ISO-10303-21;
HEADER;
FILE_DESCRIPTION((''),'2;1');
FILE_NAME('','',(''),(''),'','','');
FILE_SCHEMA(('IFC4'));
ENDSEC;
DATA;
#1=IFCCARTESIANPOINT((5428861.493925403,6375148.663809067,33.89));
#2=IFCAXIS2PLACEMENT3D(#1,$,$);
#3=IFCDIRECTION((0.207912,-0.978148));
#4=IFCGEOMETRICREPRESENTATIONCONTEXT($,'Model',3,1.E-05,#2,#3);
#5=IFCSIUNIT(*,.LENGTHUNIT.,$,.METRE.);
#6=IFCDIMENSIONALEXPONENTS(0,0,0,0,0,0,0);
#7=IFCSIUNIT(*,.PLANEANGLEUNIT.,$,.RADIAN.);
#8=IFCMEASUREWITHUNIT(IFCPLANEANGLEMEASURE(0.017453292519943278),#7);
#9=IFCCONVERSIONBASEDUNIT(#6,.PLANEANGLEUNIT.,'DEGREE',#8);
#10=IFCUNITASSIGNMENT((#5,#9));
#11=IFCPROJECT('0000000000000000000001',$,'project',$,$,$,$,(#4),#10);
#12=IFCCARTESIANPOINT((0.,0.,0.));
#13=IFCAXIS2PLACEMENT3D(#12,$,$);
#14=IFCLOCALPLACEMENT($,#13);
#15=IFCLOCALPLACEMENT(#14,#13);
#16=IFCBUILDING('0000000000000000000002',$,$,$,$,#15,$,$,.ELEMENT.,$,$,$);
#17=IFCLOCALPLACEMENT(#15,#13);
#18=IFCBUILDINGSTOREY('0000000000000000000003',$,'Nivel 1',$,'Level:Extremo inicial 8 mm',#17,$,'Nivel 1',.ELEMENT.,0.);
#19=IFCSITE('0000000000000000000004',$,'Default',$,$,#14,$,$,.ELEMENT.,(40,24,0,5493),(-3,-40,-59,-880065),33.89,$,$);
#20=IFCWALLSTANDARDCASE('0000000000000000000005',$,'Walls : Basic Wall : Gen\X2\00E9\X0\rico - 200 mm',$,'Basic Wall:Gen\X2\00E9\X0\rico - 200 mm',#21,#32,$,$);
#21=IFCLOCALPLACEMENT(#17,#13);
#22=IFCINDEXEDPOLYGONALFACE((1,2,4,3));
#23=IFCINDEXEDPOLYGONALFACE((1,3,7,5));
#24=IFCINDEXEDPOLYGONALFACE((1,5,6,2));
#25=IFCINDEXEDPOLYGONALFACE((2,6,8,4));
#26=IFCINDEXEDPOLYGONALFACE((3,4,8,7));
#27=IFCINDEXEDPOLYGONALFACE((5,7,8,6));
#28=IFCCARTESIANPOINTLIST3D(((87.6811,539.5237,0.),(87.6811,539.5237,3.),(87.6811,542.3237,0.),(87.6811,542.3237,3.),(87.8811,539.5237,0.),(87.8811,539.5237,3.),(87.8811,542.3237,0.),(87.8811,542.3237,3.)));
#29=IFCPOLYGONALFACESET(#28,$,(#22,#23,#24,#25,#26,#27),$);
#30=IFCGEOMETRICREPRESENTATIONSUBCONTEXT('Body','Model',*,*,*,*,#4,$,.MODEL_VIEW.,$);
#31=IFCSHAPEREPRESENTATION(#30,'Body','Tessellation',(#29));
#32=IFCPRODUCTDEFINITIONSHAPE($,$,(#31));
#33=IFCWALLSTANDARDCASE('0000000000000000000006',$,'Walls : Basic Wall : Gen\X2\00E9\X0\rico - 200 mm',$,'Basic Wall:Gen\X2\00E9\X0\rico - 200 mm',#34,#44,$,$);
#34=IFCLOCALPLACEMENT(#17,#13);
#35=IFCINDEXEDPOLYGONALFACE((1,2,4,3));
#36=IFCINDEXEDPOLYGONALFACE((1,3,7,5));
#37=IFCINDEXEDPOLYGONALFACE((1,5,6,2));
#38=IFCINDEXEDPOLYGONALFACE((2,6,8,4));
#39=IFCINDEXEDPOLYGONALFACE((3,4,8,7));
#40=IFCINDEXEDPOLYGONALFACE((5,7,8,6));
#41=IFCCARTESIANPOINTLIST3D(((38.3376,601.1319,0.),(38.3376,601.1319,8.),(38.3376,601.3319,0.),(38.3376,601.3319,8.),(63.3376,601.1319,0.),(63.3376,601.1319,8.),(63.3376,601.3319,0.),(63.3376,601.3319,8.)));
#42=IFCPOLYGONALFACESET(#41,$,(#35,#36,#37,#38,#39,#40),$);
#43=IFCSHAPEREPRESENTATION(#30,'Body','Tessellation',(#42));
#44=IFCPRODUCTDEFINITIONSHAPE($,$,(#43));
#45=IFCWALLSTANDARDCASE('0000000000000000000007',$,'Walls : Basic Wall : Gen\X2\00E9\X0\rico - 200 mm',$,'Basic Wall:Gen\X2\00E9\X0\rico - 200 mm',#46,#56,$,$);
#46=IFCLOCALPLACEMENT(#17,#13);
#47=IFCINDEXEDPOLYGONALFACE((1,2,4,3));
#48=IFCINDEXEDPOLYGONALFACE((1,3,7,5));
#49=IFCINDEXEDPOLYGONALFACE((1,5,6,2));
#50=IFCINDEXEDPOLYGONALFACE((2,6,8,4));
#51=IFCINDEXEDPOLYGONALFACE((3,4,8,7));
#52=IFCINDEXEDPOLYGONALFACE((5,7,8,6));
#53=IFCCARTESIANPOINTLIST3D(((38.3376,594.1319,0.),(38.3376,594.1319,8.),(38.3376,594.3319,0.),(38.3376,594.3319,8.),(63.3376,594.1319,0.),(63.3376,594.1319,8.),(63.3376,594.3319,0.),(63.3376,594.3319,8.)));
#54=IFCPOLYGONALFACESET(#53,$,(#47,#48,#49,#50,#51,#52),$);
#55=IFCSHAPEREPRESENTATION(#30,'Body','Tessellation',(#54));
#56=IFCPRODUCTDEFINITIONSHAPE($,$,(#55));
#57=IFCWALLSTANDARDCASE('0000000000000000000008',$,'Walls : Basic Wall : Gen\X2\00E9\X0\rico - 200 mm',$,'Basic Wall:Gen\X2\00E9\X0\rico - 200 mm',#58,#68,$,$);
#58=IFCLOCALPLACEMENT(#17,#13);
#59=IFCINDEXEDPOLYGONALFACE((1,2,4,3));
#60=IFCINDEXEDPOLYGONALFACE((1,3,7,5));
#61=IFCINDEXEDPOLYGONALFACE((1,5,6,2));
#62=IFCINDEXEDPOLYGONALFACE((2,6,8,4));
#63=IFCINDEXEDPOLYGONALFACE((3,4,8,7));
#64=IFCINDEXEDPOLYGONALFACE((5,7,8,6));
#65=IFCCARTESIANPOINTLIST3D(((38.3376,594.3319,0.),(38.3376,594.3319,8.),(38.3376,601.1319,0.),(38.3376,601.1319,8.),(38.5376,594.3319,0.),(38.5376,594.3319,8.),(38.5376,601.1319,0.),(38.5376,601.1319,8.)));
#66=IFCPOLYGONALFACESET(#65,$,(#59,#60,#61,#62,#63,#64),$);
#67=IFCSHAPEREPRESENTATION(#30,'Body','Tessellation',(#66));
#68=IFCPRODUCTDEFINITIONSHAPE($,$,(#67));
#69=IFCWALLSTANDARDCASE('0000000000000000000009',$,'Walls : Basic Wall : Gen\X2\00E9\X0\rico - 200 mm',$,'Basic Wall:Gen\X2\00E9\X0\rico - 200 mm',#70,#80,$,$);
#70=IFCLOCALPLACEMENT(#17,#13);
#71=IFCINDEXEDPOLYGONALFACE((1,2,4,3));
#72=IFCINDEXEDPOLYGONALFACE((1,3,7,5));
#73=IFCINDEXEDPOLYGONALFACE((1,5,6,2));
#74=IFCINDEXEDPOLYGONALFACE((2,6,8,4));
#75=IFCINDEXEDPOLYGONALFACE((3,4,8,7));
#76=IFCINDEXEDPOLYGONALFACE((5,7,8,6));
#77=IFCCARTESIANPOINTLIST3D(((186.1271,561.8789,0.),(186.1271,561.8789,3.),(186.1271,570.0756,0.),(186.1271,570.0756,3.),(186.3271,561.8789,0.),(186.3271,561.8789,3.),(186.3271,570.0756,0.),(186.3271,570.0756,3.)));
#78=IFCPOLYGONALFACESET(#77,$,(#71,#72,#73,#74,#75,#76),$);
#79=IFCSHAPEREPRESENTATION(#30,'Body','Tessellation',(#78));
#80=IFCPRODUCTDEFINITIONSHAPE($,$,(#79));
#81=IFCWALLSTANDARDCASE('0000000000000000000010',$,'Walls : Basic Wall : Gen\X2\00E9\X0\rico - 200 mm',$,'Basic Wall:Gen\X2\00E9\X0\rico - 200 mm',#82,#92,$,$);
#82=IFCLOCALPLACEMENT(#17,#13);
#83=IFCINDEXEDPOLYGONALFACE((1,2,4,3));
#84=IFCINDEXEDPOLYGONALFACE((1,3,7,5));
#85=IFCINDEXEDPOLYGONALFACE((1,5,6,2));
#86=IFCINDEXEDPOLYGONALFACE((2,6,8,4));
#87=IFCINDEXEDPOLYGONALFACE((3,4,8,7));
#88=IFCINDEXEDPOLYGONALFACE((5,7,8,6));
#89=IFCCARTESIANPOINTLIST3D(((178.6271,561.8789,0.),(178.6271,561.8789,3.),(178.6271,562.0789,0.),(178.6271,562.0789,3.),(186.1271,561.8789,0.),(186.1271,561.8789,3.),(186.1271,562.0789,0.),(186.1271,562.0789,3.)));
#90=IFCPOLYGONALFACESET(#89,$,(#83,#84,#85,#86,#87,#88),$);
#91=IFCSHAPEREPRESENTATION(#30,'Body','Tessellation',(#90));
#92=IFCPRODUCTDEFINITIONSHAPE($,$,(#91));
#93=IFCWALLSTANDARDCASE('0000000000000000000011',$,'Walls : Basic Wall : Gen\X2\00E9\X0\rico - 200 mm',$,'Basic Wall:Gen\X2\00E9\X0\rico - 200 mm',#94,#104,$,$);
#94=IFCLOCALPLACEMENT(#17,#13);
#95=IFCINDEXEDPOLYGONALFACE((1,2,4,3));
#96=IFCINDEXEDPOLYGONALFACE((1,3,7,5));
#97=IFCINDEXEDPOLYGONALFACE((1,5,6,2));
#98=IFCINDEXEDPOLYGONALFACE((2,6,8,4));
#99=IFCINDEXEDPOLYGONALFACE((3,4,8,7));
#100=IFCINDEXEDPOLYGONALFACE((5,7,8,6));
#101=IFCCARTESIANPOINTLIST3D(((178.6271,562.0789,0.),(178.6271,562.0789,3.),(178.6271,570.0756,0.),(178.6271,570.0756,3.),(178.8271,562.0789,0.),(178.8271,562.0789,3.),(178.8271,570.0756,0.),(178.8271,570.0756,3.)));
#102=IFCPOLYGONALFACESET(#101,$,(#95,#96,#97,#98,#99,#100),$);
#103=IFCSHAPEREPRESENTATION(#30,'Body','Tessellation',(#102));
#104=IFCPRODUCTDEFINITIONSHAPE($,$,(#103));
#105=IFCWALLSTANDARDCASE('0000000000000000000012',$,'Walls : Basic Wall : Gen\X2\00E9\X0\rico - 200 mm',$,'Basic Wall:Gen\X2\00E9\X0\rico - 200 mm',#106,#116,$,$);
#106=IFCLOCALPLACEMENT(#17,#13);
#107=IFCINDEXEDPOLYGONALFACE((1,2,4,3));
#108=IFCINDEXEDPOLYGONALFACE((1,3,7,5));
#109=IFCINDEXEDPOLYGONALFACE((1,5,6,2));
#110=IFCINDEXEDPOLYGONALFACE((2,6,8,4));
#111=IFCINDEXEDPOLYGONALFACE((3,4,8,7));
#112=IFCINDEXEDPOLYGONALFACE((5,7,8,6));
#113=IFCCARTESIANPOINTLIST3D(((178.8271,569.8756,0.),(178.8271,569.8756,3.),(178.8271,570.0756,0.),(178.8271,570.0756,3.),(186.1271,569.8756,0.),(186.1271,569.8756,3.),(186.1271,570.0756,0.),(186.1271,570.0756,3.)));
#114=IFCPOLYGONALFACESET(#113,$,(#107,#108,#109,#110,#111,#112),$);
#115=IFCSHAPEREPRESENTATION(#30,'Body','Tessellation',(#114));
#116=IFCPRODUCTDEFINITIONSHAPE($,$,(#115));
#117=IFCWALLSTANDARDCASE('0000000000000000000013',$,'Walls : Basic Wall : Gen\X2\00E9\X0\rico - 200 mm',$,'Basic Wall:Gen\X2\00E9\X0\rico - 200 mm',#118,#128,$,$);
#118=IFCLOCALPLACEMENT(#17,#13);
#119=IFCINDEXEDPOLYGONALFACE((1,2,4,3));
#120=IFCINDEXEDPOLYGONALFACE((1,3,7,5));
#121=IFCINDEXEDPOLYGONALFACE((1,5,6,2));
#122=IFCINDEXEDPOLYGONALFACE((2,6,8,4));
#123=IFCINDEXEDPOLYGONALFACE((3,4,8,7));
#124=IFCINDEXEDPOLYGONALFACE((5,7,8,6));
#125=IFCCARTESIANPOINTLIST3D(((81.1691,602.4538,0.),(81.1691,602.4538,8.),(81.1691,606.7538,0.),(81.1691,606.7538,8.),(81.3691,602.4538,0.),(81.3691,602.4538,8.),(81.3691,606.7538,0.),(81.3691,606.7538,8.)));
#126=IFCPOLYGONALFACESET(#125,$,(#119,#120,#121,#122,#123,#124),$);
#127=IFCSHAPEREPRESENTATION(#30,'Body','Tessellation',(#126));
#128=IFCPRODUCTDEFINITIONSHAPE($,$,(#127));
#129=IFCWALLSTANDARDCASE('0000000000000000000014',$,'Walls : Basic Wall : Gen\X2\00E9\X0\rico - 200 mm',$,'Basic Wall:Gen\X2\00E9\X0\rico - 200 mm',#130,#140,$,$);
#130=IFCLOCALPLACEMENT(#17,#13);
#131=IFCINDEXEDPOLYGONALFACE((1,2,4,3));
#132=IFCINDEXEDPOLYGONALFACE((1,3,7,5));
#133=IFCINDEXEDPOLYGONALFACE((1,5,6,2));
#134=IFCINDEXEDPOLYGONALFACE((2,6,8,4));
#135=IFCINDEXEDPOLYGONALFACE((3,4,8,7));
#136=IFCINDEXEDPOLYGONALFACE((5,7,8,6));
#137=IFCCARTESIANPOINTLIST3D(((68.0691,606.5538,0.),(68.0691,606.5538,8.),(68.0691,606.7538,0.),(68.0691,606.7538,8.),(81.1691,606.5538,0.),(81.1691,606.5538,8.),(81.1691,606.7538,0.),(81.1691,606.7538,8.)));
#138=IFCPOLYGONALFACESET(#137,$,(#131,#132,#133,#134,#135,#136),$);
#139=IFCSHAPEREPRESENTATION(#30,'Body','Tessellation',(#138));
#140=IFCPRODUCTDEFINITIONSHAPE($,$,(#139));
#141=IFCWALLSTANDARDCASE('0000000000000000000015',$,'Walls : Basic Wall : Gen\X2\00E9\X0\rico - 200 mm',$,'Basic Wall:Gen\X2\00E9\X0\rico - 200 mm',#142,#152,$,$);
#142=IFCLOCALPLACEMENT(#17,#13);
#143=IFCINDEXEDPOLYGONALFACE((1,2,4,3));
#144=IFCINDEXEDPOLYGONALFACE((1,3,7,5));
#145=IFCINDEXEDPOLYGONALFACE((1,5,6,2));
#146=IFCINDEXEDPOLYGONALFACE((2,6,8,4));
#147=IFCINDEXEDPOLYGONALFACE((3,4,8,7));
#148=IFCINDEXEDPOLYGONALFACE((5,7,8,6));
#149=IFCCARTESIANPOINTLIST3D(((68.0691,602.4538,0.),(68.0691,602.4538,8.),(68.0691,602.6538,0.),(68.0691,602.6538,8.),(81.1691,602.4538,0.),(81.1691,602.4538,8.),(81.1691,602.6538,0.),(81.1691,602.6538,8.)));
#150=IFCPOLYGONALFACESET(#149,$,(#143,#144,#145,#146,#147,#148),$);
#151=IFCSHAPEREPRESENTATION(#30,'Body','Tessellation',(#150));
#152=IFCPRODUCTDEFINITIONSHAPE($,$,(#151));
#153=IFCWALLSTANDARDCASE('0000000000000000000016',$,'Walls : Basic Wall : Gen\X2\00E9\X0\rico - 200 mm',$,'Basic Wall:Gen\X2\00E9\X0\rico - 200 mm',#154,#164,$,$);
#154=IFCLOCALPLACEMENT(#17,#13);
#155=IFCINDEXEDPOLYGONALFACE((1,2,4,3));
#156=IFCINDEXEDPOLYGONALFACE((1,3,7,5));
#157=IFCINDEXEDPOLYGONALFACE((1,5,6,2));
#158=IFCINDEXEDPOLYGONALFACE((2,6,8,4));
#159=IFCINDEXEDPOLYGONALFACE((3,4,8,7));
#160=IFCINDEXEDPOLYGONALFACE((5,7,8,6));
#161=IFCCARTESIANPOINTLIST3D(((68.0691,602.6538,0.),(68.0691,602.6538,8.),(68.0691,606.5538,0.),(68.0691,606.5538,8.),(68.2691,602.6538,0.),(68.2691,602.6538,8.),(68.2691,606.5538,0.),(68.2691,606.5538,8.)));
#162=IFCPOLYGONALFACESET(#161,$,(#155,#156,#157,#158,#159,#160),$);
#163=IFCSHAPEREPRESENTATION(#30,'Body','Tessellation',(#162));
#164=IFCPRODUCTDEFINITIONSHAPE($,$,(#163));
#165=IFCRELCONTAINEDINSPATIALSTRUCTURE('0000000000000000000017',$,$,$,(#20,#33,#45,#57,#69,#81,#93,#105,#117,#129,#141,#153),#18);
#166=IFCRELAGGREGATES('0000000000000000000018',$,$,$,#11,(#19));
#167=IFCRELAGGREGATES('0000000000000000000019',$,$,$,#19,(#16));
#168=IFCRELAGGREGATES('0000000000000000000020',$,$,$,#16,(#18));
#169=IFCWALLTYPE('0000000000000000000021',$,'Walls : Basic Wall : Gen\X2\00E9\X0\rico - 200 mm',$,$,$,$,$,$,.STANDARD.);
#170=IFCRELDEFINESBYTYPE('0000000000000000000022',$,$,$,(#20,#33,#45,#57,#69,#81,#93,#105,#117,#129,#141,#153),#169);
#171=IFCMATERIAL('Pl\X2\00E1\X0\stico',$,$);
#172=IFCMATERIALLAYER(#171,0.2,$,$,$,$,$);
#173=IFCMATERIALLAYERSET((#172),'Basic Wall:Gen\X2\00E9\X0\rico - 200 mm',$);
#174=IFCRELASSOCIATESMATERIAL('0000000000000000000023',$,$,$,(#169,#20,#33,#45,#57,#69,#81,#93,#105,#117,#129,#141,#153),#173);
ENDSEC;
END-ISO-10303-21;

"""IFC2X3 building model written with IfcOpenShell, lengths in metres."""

from ifc_helpers import new_model, entity, si_unit, converted_unit, direction, frame, frame_2d, origin, place, context, subcontext, project, spatial, rectangle, extrude, material, layer, layer_set, layer_usage, type_object, element, save


model = new_model("IFC2X3")

# Units and contexts
model_context = context("Model", 3, precision=1e-05, world=frame((5428861.493925403, 6375148.663809067, 33.89)), true_north=direction((0.207912, -0.978148)))
body_context = subcontext(model_context, "Body", "Model", "MODEL_VIEW")
ifc_project = project(units=[si_unit("LENGTHUNIT", "METRE"), converted_unit("PLANEANGLEUNIT", "DEGREE", entity("IfcPlaneAngleMeasure", 0.017453292519943278), si_unit("PLANEANGLEUNIT", "RADIAN"), dimensions=[0, 0, 0, 0, 0, 0, 0])], contexts=[model_context])

# Site, building, storey
site_placement = place(None, origin())
site = spatial("IfcSite", under=ifc_project, at=site_placement, Name="Default", CompositionType="ELEMENT", RefLatitude=(40, 24, 0, 5493), RefLongitude=(-3, -40, -59, -880065), RefElevation=33.89)
building_placement = place(site_placement, origin())
building = spatial("IfcBuilding", under=site, at=building_placement, CompositionType="ELEMENT")
storey_placement = place(building_placement, origin())
storey = spatial("IfcBuildingStorey", under=building, at=storey_placement, Name="Nivel 1", ObjectType="Level:Extremo inicial 8 mm", LongName="Nivel 1", CompositionType="ELEMENT", Elevation=0.0)

# Walls
ifc_material_1 = material(Name="Plástico")
ifc_layer_1 = layer(ifc_material_1, 0.2)
ifc_layer_set_1 = layer_set([ifc_layer_1], Name="Basic Wall:Genérico - 200 mm")
wall_type = type_object("IfcWallType", Name="Walls : Basic Wall : Genérico - 200 mm", PredefinedType="STANDARD", material=ifc_layer_set_1)
ifc_layer_usage_1 = layer_usage(ifc_layer_set_1, "AXIS2", "NEGATIVE", 0.1)
wall_1_placement = place(storey_placement, frame((87.7811, 542.3237, 0.0), z_axis=(0.0, 0.0, 1.0), x_axis=(0.0, -1.0, 0.0)))
element("IfcWallStandardCase", 1, at=wall_1_placement, inside=storey, type_object=wall_type, material=ifc_layer_usage_1, Name="Walls : Basic Wall : Genérico - 200 mm", ObjectType="Basic Wall:Genérico - 200 mm", context=body_context, shape_type="SweptSolid", body=[
    extrude(rectangle(XDim=2.8, YDim=0.2, at=frame_2d((1.4, 0.0), x_axis=(-1.0, 0.0))), origin(), (0.0, 0.0, 1.0), 3.0),
])
ifc_layer_usage_2 = layer_usage(ifc_layer_set_1, "AXIS2", "NEGATIVE", 0.1)
wall_2_placement = place(storey_placement, frame((63.3376, 601.2319, 0.0), z_axis=(0.0, 0.0, 1.0), x_axis=(-1.0, 0.0, 0.0)))
element("IfcWallStandardCase", 2, at=wall_2_placement, inside=storey, type_object=wall_type, material=ifc_layer_usage_2, Name="Walls : Basic Wall : Genérico - 200 mm", ObjectType="Basic Wall:Genérico - 200 mm", context=body_context, shape_type="SweptSolid", body=[
    extrude(rectangle(XDim=25.0, YDim=0.2, at=frame_2d((12.5, 0.0), x_axis=(-1.0, 0.0))), origin(), (0.0, 0.0, 1.0), 8.0),
])
ifc_layer_usage_3 = layer_usage(ifc_layer_set_1, "AXIS2", "NEGATIVE", 0.1)
wall_3_placement = place(storey_placement, frame((63.3376, 594.2319, 0.0), z_axis=(0.0, 0.0, 1.0), x_axis=(-1.0, 0.0, 0.0)))
element("IfcWallStandardCase", 3, at=wall_3_placement, inside=storey, type_object=wall_type, material=ifc_layer_usage_3, Name="Walls : Basic Wall : Genérico - 200 mm", ObjectType="Basic Wall:Genérico - 200 mm", context=body_context, shape_type="SweptSolid", body=[
    extrude(rectangle(XDim=25.0, YDim=0.2, at=frame_2d((12.5, 0.0), x_axis=(-1.0, 0.0))), origin(), (0.0, 0.0, 1.0), 8.0),
])
ifc_layer_usage_4 = layer_usage(ifc_layer_set_1, "AXIS2", "NEGATIVE", 0.1)
wall_4_placement = place(storey_placement, frame((38.4376, 594.3319, 0.0), z_axis=(0.0, 0.0, 1.0), x_axis=(0.0, 1.0, 0.0)))
element("IfcWallStandardCase", 4, at=wall_4_placement, inside=storey, type_object=wall_type, material=ifc_layer_usage_4, Name="Walls : Basic Wall : Genérico - 200 mm", ObjectType="Basic Wall:Genérico - 200 mm", context=body_context, shape_type="SweptSolid", body=[
    extrude(rectangle(XDim=6.8, YDim=0.2, at=frame_2d((3.4, 0.0), x_axis=(-1.0, 0.0))), origin(), (0.0, 0.0, 1.0), 8.0),
])
ifc_layer_usage_5 = layer_usage(ifc_layer_set_1, "AXIS2", "NEGATIVE", 0.1)
wall_5_placement = place(storey_placement, frame((186.2271, 570.0756, 0.0), z_axis=(0.0, 0.0, 1.0), x_axis=(0.0, -1.0, 0.0)))
element("IfcWallStandardCase", 5, at=wall_5_placement, inside=storey, type_object=wall_type, material=ifc_layer_usage_5, Name="Walls : Basic Wall : Genérico - 200 mm", ObjectType="Basic Wall:Genérico - 200 mm", context=body_context, shape_type="SweptSolid", body=[
    extrude(rectangle(XDim=8.1967, YDim=0.2, at=frame_2d((4.0984, 0.0), x_axis=(-1.0, 0.0))), origin(), (0.0, 0.0, 1.0), 3.0),
])
ifc_layer_usage_6 = layer_usage(ifc_layer_set_1, "AXIS2", "NEGATIVE", 0.1)
wall_6_placement = place(storey_placement, frame((186.1271, 561.9789, 0.0), z_axis=(0.0, 0.0, 1.0), x_axis=(-1.0, 0.0, 0.0)))
element("IfcWallStandardCase", 6, at=wall_6_placement, inside=storey, type_object=wall_type, material=ifc_layer_usage_6, Name="Walls : Basic Wall : Genérico - 200 mm", ObjectType="Basic Wall:Genérico - 200 mm", context=body_context, shape_type="SweptSolid", body=[
    extrude(rectangle(XDim=7.5, YDim=0.2, at=frame_2d((3.75, 0.0), x_axis=(-1.0, 0.0))), origin(), (0.0, 0.0, 1.0), 3.0),
])
ifc_layer_usage_7 = layer_usage(ifc_layer_set_1, "AXIS2", "NEGATIVE", 0.1)
wall_7_placement = place(storey_placement, frame((178.7271, 562.0789, 0.0), z_axis=(0.0, 0.0, 1.0), x_axis=(0.0, 1.0, 0.0)))
element("IfcWallStandardCase", 7, at=wall_7_placement, inside=storey, type_object=wall_type, material=ifc_layer_usage_7, Name="Walls : Basic Wall : Genérico - 200 mm", ObjectType="Basic Wall:Genérico - 200 mm", context=body_context, shape_type="SweptSolid", body=[
    extrude(rectangle(XDim=7.9967, YDim=0.2, at=frame_2d((3.9984, 0.0), x_axis=(-1.0, 0.0))), origin(), (0.0, 0.0, 1.0), 3.0),
])
ifc_layer_usage_8 = layer_usage(ifc_layer_set_1, "AXIS2", "NEGATIVE", 0.1)
wall_8_placement = place(storey_placement, frame((186.1271, 569.9756, 0.0), z_axis=(0.0, 0.0, 1.0), x_axis=(-1.0, 0.0, 0.0)))
element("IfcWallStandardCase", 8, at=wall_8_placement, inside=storey, type_object=wall_type, material=ifc_layer_usage_8, Name="Walls : Basic Wall : Genérico - 200 mm", ObjectType="Basic Wall:Genérico - 200 mm", context=body_context, shape_type="SweptSolid", body=[
    extrude(rectangle(XDim=7.3, YDim=0.2, at=frame_2d((3.65, 0.0), x_axis=(-1.0, 0.0))), origin(), (0.0, 0.0, 1.0), 3.0),
])
ifc_layer_usage_9 = layer_usage(ifc_layer_set_1, "AXIS2", "NEGATIVE", 0.1)
wall_9_placement = place(storey_placement, frame((81.2691, 602.4538, 0.0), z_axis=(0.0, 0.0, 1.0), x_axis=(0.0, 1.0, 0.0)))
element("IfcWallStandardCase", 9, at=wall_9_placement, inside=storey, type_object=wall_type, material=ifc_layer_usage_9, Name="Walls : Basic Wall : Genérico - 200 mm", ObjectType="Basic Wall:Genérico - 200 mm", context=body_context, shape_type="SweptSolid", body=[
    extrude(rectangle(XDim=4.3, YDim=0.2, at=frame_2d((2.15, 0.0), x_axis=(-1.0, 0.0))), origin(), (0.0, 0.0, 1.0), 8.0),
])
ifc_layer_usage_10 = layer_usage(ifc_layer_set_1, "AXIS2", "NEGATIVE", 0.1)
wall_10_placement = place(storey_placement, frame((81.1691, 606.6538, 0.0), z_axis=(0.0, 0.0, 1.0), x_axis=(-1.0, 0.0, 0.0)))
element("IfcWallStandardCase", 10, at=wall_10_placement, inside=storey, type_object=wall_type, material=ifc_layer_usage_10, Name="Walls : Basic Wall : Genérico - 200 mm", ObjectType="Basic Wall:Genérico - 200 mm", context=body_context, shape_type="SweptSolid", body=[
    extrude(rectangle(XDim=13.1, YDim=0.2, at=frame_2d((6.55, 0.0), x_axis=(-1.0, 0.0))), origin(), (0.0, 0.0, 1.0), 8.0),
])
ifc_layer_usage_11 = layer_usage(ifc_layer_set_1, "AXIS2", "NEGATIVE", 0.1)
wall_11_placement = place(storey_placement, frame((81.1691, 602.5538, 0.0), z_axis=(0.0, 0.0, 1.0), x_axis=(-1.0, 0.0, 0.0)))
element("IfcWallStandardCase", 11, at=wall_11_placement, inside=storey, type_object=wall_type, material=ifc_layer_usage_11, Name="Walls : Basic Wall : Genérico - 200 mm", ObjectType="Basic Wall:Genérico - 200 mm", context=body_context, shape_type="SweptSolid", body=[
    extrude(rectangle(XDim=13.1, YDim=0.2, at=frame_2d((6.55, 0.0), x_axis=(-1.0, 0.0))), origin(), (0.0, 0.0, 1.0), 8.0),
])
ifc_layer_usage_12 = layer_usage(ifc_layer_set_1, "AXIS2", "NEGATIVE", 0.1)
wall_12_placement = place(storey_placement, frame((68.1691, 602.6538, 0.0), z_axis=(0.0, 0.0, 1.0), x_axis=(0.0, 1.0, 0.0)))
element("IfcWallStandardCase", 12, at=wall_12_placement, inside=storey, type_object=wall_type, material=ifc_layer_usage_12, Name="Walls : Basic Wall : Genérico - 200 mm", ObjectType="Basic Wall:Genérico - 200 mm", context=body_context, shape_type="SweptSolid", body=[
    extrude(rectangle(XDim=3.9, YDim=0.2, at=frame_2d((1.95, 0.0), x_axis=(-1.0, 0.0))), origin(), (0.0, 0.0, 1.0), 8.0),
])

save(model, "model.ifc")
